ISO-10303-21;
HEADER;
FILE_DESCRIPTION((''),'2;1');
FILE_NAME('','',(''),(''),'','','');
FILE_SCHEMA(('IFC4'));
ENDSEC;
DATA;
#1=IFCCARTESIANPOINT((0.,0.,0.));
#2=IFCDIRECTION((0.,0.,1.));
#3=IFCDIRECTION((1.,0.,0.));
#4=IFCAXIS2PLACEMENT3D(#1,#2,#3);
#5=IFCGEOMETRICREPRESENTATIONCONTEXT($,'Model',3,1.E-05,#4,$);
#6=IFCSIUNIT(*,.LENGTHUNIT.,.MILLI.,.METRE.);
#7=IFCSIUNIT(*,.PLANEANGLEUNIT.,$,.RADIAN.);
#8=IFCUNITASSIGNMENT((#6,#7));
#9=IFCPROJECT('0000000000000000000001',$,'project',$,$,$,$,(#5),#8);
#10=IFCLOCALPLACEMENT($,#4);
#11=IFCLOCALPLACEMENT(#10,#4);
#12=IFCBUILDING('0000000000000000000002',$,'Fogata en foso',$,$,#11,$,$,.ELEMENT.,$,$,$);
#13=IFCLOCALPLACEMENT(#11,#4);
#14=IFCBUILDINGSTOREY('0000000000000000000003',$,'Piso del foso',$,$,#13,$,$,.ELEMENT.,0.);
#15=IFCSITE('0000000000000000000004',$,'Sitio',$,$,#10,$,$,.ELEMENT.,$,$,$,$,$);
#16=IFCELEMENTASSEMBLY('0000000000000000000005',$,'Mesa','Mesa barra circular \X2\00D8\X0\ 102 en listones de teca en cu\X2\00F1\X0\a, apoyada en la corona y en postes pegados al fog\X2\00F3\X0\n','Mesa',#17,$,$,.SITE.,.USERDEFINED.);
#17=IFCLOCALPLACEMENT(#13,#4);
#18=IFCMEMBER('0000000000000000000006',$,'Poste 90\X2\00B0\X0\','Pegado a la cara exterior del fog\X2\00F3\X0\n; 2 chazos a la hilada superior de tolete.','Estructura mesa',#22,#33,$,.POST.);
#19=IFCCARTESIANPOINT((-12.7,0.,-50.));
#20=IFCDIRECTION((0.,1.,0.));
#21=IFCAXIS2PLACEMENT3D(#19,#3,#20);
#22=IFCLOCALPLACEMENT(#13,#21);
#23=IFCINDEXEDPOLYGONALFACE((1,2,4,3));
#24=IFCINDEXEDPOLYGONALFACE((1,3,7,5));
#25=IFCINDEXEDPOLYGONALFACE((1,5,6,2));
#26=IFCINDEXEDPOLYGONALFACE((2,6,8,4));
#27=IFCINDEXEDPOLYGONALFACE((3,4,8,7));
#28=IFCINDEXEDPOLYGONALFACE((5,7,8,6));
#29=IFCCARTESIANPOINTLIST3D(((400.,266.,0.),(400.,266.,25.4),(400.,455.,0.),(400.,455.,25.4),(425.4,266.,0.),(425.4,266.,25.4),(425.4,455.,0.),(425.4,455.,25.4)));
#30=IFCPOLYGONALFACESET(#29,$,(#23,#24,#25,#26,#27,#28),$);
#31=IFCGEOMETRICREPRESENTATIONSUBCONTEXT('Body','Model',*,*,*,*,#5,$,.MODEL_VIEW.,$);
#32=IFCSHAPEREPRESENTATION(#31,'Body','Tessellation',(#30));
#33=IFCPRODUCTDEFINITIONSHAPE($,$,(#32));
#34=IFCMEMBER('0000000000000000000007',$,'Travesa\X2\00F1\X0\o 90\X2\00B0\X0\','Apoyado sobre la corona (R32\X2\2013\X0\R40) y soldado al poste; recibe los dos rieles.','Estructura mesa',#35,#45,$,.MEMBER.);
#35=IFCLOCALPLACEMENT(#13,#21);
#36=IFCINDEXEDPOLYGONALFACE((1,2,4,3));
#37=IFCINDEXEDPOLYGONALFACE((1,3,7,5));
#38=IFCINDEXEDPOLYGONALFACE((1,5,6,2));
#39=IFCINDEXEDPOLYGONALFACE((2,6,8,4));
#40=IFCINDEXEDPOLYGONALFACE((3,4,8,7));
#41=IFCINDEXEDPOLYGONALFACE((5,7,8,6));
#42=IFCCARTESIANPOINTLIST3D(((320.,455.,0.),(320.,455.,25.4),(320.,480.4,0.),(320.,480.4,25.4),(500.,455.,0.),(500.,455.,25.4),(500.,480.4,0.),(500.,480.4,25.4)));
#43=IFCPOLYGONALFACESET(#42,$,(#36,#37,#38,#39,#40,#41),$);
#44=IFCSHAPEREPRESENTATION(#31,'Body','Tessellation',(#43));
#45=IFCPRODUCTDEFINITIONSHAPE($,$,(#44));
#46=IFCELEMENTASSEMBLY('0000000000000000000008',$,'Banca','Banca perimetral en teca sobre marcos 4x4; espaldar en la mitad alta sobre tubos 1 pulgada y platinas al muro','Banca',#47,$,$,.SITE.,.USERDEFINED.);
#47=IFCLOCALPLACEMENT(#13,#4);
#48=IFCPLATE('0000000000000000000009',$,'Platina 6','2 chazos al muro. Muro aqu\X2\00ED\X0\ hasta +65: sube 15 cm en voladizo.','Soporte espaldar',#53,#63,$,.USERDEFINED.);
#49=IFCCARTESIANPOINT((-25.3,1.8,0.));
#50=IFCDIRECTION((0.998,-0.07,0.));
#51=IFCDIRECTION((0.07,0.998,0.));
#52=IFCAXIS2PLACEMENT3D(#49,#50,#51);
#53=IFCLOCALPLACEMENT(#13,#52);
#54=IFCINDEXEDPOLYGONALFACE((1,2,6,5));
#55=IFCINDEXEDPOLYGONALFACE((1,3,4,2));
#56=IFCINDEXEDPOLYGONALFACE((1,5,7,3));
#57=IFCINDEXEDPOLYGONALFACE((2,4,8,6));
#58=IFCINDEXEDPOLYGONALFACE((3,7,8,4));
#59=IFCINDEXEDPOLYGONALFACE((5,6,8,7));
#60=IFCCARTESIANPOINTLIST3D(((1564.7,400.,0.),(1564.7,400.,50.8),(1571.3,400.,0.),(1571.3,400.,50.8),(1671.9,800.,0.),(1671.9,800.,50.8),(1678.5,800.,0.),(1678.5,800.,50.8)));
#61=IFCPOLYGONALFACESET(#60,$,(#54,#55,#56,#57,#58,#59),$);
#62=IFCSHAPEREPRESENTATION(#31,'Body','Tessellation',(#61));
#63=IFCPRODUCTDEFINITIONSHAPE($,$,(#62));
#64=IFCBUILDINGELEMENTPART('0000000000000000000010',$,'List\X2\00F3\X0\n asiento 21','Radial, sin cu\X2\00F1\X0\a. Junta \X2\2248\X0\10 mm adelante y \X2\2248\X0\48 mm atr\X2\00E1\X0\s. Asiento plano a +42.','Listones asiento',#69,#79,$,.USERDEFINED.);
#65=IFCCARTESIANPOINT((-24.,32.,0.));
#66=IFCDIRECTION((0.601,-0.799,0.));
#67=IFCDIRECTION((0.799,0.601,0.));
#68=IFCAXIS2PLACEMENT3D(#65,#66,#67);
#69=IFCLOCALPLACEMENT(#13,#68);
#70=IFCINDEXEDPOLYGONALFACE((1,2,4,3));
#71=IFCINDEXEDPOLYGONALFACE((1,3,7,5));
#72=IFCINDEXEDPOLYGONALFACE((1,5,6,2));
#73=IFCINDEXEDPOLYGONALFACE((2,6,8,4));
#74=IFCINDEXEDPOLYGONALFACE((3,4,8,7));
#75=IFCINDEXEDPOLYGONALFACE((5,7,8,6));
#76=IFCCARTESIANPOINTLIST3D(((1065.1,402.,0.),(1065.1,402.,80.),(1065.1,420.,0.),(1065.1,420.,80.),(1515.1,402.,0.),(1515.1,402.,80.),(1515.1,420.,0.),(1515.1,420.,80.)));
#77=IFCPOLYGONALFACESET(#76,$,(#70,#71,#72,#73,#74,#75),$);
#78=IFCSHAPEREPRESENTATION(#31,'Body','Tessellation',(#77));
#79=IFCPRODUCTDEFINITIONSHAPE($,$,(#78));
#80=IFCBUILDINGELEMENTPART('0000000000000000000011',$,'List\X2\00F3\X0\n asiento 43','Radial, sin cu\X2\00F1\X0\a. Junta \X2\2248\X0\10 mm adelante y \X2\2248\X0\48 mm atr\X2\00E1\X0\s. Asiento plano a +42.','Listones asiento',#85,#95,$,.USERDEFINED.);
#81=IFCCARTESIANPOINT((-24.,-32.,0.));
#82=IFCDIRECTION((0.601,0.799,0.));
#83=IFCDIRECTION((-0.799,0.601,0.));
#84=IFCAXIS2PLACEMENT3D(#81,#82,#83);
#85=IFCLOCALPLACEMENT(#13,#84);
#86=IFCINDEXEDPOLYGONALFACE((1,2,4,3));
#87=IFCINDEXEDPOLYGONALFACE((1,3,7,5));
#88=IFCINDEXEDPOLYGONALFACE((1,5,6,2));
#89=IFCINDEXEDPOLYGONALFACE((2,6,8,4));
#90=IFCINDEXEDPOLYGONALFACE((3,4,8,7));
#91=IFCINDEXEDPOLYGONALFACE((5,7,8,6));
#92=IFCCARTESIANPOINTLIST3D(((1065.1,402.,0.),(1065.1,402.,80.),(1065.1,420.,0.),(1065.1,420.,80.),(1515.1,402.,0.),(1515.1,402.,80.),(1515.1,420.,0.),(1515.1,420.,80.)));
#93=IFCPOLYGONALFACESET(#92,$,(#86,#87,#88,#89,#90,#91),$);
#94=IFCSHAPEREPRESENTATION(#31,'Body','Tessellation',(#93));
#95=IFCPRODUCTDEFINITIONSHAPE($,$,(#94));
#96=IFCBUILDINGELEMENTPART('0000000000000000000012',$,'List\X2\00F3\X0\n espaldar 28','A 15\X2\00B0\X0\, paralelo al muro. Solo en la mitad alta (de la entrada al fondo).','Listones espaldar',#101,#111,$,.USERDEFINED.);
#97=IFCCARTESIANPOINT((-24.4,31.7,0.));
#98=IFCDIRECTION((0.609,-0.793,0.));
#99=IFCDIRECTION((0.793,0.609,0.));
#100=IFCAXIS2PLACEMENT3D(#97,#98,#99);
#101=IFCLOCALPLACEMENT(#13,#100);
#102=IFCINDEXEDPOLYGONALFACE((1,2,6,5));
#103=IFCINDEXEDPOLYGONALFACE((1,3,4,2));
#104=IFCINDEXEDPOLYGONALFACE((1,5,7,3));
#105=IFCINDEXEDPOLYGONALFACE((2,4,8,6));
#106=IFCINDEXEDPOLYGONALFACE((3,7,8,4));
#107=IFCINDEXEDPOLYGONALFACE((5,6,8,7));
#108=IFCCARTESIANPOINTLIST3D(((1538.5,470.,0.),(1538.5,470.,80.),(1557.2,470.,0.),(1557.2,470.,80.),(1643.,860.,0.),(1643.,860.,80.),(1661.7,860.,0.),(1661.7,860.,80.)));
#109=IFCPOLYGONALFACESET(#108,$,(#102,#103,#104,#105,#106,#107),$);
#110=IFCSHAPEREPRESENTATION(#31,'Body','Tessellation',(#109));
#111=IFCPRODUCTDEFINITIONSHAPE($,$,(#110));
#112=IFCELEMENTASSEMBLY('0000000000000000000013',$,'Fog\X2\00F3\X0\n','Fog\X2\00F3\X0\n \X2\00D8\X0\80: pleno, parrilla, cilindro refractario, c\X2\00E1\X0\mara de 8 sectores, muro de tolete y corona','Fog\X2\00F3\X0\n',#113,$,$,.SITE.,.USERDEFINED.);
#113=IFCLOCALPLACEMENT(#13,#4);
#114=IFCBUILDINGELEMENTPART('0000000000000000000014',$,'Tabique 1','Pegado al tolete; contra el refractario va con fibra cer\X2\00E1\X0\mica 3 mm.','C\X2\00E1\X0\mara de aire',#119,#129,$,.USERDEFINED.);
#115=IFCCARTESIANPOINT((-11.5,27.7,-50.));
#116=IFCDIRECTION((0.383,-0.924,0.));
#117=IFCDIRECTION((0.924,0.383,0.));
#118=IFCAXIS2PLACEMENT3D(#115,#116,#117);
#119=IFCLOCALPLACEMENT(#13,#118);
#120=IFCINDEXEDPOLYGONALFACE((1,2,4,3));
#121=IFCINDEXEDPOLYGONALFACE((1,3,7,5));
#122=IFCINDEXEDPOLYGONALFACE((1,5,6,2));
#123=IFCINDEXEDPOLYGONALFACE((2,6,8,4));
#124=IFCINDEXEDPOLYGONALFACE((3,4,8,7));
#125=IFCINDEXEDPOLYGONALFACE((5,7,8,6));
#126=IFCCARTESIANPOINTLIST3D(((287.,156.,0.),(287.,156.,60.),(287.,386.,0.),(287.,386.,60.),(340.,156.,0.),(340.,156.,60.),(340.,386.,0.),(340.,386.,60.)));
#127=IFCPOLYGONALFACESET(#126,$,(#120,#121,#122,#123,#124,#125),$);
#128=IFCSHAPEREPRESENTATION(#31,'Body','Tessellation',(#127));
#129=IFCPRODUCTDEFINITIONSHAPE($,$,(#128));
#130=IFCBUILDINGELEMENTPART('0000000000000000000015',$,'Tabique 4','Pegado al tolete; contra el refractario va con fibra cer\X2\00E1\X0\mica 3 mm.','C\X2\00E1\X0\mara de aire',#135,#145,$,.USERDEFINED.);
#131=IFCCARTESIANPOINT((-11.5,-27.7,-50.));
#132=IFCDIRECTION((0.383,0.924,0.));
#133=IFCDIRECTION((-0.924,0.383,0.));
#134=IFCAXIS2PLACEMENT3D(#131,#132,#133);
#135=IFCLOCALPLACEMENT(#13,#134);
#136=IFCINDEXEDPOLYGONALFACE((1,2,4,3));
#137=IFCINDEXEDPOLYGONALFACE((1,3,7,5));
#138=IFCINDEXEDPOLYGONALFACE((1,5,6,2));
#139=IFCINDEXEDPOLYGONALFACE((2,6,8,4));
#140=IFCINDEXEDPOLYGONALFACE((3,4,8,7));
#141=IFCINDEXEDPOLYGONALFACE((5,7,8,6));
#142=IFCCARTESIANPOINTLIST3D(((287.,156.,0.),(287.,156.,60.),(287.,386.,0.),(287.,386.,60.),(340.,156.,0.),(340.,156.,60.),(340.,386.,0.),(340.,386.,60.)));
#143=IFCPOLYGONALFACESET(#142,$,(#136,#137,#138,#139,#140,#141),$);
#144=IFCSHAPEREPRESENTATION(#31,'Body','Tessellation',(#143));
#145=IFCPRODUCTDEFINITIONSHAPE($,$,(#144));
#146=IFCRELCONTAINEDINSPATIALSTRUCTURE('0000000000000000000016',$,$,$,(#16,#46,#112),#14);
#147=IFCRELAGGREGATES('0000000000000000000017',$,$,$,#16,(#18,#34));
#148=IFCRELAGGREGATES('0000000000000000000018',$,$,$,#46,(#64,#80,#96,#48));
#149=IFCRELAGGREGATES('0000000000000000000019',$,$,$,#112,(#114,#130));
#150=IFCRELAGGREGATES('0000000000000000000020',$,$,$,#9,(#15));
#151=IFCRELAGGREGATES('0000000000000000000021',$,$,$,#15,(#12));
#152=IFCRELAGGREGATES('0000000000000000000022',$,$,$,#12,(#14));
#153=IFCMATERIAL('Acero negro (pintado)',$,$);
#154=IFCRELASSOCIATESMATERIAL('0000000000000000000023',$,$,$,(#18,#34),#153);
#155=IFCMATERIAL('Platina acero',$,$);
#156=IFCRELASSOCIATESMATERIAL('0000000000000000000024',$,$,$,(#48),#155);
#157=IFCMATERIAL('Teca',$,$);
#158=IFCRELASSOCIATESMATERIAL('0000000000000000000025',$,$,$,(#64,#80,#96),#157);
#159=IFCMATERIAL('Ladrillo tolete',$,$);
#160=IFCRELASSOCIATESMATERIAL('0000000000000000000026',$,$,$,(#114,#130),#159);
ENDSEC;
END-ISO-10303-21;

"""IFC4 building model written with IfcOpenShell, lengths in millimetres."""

from ifc_helpers import new_model, si_unit, frame, origin_with_axes, place, context, subcontext, project, spatial, polyline, outline, extrude, material, element, aggregate, save


model = new_model("IFC4")

# Units and contexts
model_context = context("Model", 3, precision=1e-05, world=origin_with_axes())
body_context = subcontext(model_context, "Body", "Model", "MODEL_VIEW")
ifc_project = project(units=[si_unit("LENGTHUNIT", "METRE", prefix="MILLI"), si_unit("PLANEANGLEUNIT", "RADIAN")], contexts=[model_context])

# Site, building, storey
site_placement = place(None, origin_with_axes())
site = spatial("IfcSite", under=ifc_project, at=site_placement, Name="Sitio", CompositionType="ELEMENT")
building_placement = place(site_placement, origin_with_axes())
building = spatial("IfcBuilding", under=site, at=building_placement, Name="Fogata en foso", CompositionType="ELEMENT")
storey_placement = place(building_placement, origin_with_axes())
storey = spatial("IfcBuildingStorey", under=building, at=storey_placement, Name="Piso del foso", CompositionType="ELEMENT", Elevation=0.0)

# Element assembly, members
assembly_1_placement = place(storey_placement, origin_with_axes())
assembly_1 = element("IfcElementAssembly", 1, at=assembly_1_placement, inside=storey, Name="Mesa", Description="Mesa barra circular Ø 102 en listones de teca en cuña, apoyada en la corona y en postes pegados al fogón", ObjectType="Mesa", AssemblyPlace="SITE", PredefinedType="USERDEFINED")
ifc_material_1 = material(Name="Acero negro (pintado)")
member_1_placement = place(storey_placement, frame((-12.7, 0.0, -50.0), z_axis=(1.0, 0.0, 0.0), x_axis=(0.0, 1.0, 0.0)))
member_1 = element("IfcMember", 2, at=member_1_placement, material=ifc_material_1, Name="Poste 90°", Description="Pegado a la cara exterior del fogón; 2 chazos a la hilada superior de tolete.", ObjectType="Estructura mesa", PredefinedType="POST", context=body_context, shape_type="SweptSolid", body=[
    extrude(outline(polyline([(400.0, 266.0), (425.4, 266.0), (425.4, 455.0), (400.0, 455.0), (400.0, 266.0)])), origin_with_axes(), (0.0, 0.0, 1.0), 25.4),
])
member_2_placement = place(storey_placement, frame((-12.7, 0.0, -50.0), z_axis=(1.0, 0.0, 0.0), x_axis=(0.0, 1.0, 0.0)))
member_2 = element("IfcMember", 3, at=member_2_placement, material=ifc_material_1, Name="Travesaño 90°", Description="Apoyado sobre la corona (R32–R40) y soldado al poste; recibe los dos rieles.", ObjectType="Estructura mesa", PredefinedType="MEMBER", context=body_context, shape_type="SweptSolid", body=[
    extrude(outline(polyline([(320.0, 455.0), (500.0, 455.0), (500.0, 480.4), (320.0, 480.4), (320.0, 455.0)])), origin_with_axes(), (0.0, 0.0, 1.0), 25.4),
])
aggregate(assembly_1, [member_1, member_2])

# Element assembly, plate
assembly_2_placement = place(storey_placement, origin_with_axes())
assembly_2 = element("IfcElementAssembly", 4, at=assembly_2_placement, inside=storey, Name="Banca", Description="Banca perimetral en teca sobre marcos 4x4; espaldar en la mitad alta sobre tubos 1 pulgada y platinas al muro", ObjectType="Banca", AssemblyPlace="SITE", PredefinedType="USERDEFINED")
ifc_material_2 = material(Name="Platina acero")
plate_placement = place(storey_placement, frame((-25.3, 1.8, 0.0), z_axis=(0.998, -0.07, 0.0), x_axis=(0.07, 0.998, 0.0)))
plate = element("IfcPlate", 5, at=plate_placement, material=ifc_material_2, Name="Platina 6", Description="2 chazos al muro. Muro aquí hasta +65: sube 15 cm en voladizo.", ObjectType="Soporte espaldar", PredefinedType="USERDEFINED", context=body_context, shape_type="SweptSolid", body=[
    extrude(outline(polyline([(1564.7, 400.0), (1571.3, 400.0), (1678.5, 800.0), (1671.9, 800.0), (1564.7, 400.0)])), origin_with_axes(), (0.0, 0.0, 1.0), 50.8),
])

# Shared definitions
ifc_material_3 = material(Name="Ladrillo tolete")

# Building element parts
ifc_material_4 = material(Name="Teca")
building_element_part_1_placement = place(storey_placement, frame((-24.0, 32.0, 0.0), z_axis=(0.601, -0.799, 0.0), x_axis=(0.799, 0.601, 0.0)))
building_element_part_1 = element("IfcBuildingElementPart", 6, at=building_element_part_1_placement, material=ifc_material_4, Name="Listón asiento 21", Description="Radial, sin cuña. Junta ≈10 mm adelante y ≈48 mm atrás. Asiento plano a +42.", ObjectType="Listones asiento", PredefinedType="USERDEFINED", context=body_context, shape_type="SweptSolid", body=[
    extrude(outline(polyline([(1065.1, 402.0), (1515.1, 402.0), (1515.1, 420.0), (1065.1, 420.0), (1065.1, 402.0)])), origin_with_axes(), (0.0, 0.0, 1.0), 80.0),
])
building_element_part_2_placement = place(storey_placement, frame((-24.0, -32.0, 0.0), z_axis=(0.601, 0.799, 0.0), x_axis=(-0.799, 0.601, 0.0)))
building_element_part_2 = element("IfcBuildingElementPart", 7, at=building_element_part_2_placement, material=ifc_material_4, Name="Listón asiento 43", Description="Radial, sin cuña. Junta ≈10 mm adelante y ≈48 mm atrás. Asiento plano a +42.", ObjectType="Listones asiento", PredefinedType="USERDEFINED", context=body_context, shape_type="SweptSolid", body=[
    extrude(outline(polyline([(1065.1, 402.0), (1515.1, 402.0), (1515.1, 420.0), (1065.1, 420.0), (1065.1, 402.0)])), origin_with_axes(), (0.0, 0.0, 1.0), 80.0),
])
building_element_part_3_placement = place(storey_placement, frame((-24.4, 31.7, 0.0), z_axis=(0.609, -0.793, 0.0), x_axis=(0.793, 0.609, 0.0)))
building_element_part_3 = element("IfcBuildingElementPart", 8, at=building_element_part_3_placement, material=ifc_material_4, Name="Listón espaldar 28", Description="A 15°, paralelo al muro. Solo en la mitad alta (de la entrada al fondo).", ObjectType="Listones espaldar", PredefinedType="USERDEFINED", context=body_context, shape_type="SweptSolid", body=[
    extrude(outline(polyline([(1538.5, 470.0), (1557.2, 470.0), (1661.7, 860.0), (1643.0, 860.0), (1538.5, 470.0)])), origin_with_axes(), (0.0, 0.0, 1.0), 80.0),
])
aggregate(assembly_2, [building_element_part_1, building_element_part_2, building_element_part_3, plate])

# Element assembly, building element parts
assembly_3_placement = place(storey_placement, origin_with_axes())
assembly_3 = element("IfcElementAssembly", 9, at=assembly_3_placement, inside=storey, Name="Fogón", Description="Fogón Ø80: pleno, parrilla, cilindro refractario, cámara de 8 sectores, muro de tolete y corona", ObjectType="Fogón", AssemblyPlace="SITE", PredefinedType="USERDEFINED")
building_element_part_4_placement = place(storey_placement, frame((-11.5, 27.7, -50.0), z_axis=(0.383, -0.924, 0.0), x_axis=(0.924, 0.383, 0.0)))
building_element_part_4 = element("IfcBuildingElementPart", 10, at=building_element_part_4_placement, material=ifc_material_3, Name="Tabique 1", Description="Pegado al tolete; contra el refractario va con fibra cerámica 3 mm.", ObjectType="Cámara de aire", PredefinedType="USERDEFINED", context=body_context, shape_type="SweptSolid", body=[
    extrude(outline(polyline([(287.0, 156.0), (340.0, 156.0), (340.0, 386.0), (287.0, 386.0), (287.0, 156.0)])), origin_with_axes(), (0.0, 0.0, 1.0), 60.0),
])
building_element_part_5_placement = place(storey_placement, frame((-11.5, -27.7, -50.0), z_axis=(0.383, 0.924, 0.0), x_axis=(-0.924, 0.383, 0.0)))
building_element_part_5 = element("IfcBuildingElementPart", 11, at=building_element_part_5_placement, material=ifc_material_3, Name="Tabique 4", Description="Pegado al tolete; contra el refractario va con fibra cerámica 3 mm.", ObjectType="Cámara de aire", PredefinedType="USERDEFINED", context=body_context, shape_type="SweptSolid", body=[
    extrude(outline(polyline([(287.0, 156.0), (340.0, 156.0), (340.0, 386.0), (287.0, 386.0), (287.0, 156.0)])), origin_with_axes(), (0.0, 0.0, 1.0), 60.0),
])
aggregate(assembly_3, [building_element_part_4, building_element_part_5])

save(model, "model.ifc")
